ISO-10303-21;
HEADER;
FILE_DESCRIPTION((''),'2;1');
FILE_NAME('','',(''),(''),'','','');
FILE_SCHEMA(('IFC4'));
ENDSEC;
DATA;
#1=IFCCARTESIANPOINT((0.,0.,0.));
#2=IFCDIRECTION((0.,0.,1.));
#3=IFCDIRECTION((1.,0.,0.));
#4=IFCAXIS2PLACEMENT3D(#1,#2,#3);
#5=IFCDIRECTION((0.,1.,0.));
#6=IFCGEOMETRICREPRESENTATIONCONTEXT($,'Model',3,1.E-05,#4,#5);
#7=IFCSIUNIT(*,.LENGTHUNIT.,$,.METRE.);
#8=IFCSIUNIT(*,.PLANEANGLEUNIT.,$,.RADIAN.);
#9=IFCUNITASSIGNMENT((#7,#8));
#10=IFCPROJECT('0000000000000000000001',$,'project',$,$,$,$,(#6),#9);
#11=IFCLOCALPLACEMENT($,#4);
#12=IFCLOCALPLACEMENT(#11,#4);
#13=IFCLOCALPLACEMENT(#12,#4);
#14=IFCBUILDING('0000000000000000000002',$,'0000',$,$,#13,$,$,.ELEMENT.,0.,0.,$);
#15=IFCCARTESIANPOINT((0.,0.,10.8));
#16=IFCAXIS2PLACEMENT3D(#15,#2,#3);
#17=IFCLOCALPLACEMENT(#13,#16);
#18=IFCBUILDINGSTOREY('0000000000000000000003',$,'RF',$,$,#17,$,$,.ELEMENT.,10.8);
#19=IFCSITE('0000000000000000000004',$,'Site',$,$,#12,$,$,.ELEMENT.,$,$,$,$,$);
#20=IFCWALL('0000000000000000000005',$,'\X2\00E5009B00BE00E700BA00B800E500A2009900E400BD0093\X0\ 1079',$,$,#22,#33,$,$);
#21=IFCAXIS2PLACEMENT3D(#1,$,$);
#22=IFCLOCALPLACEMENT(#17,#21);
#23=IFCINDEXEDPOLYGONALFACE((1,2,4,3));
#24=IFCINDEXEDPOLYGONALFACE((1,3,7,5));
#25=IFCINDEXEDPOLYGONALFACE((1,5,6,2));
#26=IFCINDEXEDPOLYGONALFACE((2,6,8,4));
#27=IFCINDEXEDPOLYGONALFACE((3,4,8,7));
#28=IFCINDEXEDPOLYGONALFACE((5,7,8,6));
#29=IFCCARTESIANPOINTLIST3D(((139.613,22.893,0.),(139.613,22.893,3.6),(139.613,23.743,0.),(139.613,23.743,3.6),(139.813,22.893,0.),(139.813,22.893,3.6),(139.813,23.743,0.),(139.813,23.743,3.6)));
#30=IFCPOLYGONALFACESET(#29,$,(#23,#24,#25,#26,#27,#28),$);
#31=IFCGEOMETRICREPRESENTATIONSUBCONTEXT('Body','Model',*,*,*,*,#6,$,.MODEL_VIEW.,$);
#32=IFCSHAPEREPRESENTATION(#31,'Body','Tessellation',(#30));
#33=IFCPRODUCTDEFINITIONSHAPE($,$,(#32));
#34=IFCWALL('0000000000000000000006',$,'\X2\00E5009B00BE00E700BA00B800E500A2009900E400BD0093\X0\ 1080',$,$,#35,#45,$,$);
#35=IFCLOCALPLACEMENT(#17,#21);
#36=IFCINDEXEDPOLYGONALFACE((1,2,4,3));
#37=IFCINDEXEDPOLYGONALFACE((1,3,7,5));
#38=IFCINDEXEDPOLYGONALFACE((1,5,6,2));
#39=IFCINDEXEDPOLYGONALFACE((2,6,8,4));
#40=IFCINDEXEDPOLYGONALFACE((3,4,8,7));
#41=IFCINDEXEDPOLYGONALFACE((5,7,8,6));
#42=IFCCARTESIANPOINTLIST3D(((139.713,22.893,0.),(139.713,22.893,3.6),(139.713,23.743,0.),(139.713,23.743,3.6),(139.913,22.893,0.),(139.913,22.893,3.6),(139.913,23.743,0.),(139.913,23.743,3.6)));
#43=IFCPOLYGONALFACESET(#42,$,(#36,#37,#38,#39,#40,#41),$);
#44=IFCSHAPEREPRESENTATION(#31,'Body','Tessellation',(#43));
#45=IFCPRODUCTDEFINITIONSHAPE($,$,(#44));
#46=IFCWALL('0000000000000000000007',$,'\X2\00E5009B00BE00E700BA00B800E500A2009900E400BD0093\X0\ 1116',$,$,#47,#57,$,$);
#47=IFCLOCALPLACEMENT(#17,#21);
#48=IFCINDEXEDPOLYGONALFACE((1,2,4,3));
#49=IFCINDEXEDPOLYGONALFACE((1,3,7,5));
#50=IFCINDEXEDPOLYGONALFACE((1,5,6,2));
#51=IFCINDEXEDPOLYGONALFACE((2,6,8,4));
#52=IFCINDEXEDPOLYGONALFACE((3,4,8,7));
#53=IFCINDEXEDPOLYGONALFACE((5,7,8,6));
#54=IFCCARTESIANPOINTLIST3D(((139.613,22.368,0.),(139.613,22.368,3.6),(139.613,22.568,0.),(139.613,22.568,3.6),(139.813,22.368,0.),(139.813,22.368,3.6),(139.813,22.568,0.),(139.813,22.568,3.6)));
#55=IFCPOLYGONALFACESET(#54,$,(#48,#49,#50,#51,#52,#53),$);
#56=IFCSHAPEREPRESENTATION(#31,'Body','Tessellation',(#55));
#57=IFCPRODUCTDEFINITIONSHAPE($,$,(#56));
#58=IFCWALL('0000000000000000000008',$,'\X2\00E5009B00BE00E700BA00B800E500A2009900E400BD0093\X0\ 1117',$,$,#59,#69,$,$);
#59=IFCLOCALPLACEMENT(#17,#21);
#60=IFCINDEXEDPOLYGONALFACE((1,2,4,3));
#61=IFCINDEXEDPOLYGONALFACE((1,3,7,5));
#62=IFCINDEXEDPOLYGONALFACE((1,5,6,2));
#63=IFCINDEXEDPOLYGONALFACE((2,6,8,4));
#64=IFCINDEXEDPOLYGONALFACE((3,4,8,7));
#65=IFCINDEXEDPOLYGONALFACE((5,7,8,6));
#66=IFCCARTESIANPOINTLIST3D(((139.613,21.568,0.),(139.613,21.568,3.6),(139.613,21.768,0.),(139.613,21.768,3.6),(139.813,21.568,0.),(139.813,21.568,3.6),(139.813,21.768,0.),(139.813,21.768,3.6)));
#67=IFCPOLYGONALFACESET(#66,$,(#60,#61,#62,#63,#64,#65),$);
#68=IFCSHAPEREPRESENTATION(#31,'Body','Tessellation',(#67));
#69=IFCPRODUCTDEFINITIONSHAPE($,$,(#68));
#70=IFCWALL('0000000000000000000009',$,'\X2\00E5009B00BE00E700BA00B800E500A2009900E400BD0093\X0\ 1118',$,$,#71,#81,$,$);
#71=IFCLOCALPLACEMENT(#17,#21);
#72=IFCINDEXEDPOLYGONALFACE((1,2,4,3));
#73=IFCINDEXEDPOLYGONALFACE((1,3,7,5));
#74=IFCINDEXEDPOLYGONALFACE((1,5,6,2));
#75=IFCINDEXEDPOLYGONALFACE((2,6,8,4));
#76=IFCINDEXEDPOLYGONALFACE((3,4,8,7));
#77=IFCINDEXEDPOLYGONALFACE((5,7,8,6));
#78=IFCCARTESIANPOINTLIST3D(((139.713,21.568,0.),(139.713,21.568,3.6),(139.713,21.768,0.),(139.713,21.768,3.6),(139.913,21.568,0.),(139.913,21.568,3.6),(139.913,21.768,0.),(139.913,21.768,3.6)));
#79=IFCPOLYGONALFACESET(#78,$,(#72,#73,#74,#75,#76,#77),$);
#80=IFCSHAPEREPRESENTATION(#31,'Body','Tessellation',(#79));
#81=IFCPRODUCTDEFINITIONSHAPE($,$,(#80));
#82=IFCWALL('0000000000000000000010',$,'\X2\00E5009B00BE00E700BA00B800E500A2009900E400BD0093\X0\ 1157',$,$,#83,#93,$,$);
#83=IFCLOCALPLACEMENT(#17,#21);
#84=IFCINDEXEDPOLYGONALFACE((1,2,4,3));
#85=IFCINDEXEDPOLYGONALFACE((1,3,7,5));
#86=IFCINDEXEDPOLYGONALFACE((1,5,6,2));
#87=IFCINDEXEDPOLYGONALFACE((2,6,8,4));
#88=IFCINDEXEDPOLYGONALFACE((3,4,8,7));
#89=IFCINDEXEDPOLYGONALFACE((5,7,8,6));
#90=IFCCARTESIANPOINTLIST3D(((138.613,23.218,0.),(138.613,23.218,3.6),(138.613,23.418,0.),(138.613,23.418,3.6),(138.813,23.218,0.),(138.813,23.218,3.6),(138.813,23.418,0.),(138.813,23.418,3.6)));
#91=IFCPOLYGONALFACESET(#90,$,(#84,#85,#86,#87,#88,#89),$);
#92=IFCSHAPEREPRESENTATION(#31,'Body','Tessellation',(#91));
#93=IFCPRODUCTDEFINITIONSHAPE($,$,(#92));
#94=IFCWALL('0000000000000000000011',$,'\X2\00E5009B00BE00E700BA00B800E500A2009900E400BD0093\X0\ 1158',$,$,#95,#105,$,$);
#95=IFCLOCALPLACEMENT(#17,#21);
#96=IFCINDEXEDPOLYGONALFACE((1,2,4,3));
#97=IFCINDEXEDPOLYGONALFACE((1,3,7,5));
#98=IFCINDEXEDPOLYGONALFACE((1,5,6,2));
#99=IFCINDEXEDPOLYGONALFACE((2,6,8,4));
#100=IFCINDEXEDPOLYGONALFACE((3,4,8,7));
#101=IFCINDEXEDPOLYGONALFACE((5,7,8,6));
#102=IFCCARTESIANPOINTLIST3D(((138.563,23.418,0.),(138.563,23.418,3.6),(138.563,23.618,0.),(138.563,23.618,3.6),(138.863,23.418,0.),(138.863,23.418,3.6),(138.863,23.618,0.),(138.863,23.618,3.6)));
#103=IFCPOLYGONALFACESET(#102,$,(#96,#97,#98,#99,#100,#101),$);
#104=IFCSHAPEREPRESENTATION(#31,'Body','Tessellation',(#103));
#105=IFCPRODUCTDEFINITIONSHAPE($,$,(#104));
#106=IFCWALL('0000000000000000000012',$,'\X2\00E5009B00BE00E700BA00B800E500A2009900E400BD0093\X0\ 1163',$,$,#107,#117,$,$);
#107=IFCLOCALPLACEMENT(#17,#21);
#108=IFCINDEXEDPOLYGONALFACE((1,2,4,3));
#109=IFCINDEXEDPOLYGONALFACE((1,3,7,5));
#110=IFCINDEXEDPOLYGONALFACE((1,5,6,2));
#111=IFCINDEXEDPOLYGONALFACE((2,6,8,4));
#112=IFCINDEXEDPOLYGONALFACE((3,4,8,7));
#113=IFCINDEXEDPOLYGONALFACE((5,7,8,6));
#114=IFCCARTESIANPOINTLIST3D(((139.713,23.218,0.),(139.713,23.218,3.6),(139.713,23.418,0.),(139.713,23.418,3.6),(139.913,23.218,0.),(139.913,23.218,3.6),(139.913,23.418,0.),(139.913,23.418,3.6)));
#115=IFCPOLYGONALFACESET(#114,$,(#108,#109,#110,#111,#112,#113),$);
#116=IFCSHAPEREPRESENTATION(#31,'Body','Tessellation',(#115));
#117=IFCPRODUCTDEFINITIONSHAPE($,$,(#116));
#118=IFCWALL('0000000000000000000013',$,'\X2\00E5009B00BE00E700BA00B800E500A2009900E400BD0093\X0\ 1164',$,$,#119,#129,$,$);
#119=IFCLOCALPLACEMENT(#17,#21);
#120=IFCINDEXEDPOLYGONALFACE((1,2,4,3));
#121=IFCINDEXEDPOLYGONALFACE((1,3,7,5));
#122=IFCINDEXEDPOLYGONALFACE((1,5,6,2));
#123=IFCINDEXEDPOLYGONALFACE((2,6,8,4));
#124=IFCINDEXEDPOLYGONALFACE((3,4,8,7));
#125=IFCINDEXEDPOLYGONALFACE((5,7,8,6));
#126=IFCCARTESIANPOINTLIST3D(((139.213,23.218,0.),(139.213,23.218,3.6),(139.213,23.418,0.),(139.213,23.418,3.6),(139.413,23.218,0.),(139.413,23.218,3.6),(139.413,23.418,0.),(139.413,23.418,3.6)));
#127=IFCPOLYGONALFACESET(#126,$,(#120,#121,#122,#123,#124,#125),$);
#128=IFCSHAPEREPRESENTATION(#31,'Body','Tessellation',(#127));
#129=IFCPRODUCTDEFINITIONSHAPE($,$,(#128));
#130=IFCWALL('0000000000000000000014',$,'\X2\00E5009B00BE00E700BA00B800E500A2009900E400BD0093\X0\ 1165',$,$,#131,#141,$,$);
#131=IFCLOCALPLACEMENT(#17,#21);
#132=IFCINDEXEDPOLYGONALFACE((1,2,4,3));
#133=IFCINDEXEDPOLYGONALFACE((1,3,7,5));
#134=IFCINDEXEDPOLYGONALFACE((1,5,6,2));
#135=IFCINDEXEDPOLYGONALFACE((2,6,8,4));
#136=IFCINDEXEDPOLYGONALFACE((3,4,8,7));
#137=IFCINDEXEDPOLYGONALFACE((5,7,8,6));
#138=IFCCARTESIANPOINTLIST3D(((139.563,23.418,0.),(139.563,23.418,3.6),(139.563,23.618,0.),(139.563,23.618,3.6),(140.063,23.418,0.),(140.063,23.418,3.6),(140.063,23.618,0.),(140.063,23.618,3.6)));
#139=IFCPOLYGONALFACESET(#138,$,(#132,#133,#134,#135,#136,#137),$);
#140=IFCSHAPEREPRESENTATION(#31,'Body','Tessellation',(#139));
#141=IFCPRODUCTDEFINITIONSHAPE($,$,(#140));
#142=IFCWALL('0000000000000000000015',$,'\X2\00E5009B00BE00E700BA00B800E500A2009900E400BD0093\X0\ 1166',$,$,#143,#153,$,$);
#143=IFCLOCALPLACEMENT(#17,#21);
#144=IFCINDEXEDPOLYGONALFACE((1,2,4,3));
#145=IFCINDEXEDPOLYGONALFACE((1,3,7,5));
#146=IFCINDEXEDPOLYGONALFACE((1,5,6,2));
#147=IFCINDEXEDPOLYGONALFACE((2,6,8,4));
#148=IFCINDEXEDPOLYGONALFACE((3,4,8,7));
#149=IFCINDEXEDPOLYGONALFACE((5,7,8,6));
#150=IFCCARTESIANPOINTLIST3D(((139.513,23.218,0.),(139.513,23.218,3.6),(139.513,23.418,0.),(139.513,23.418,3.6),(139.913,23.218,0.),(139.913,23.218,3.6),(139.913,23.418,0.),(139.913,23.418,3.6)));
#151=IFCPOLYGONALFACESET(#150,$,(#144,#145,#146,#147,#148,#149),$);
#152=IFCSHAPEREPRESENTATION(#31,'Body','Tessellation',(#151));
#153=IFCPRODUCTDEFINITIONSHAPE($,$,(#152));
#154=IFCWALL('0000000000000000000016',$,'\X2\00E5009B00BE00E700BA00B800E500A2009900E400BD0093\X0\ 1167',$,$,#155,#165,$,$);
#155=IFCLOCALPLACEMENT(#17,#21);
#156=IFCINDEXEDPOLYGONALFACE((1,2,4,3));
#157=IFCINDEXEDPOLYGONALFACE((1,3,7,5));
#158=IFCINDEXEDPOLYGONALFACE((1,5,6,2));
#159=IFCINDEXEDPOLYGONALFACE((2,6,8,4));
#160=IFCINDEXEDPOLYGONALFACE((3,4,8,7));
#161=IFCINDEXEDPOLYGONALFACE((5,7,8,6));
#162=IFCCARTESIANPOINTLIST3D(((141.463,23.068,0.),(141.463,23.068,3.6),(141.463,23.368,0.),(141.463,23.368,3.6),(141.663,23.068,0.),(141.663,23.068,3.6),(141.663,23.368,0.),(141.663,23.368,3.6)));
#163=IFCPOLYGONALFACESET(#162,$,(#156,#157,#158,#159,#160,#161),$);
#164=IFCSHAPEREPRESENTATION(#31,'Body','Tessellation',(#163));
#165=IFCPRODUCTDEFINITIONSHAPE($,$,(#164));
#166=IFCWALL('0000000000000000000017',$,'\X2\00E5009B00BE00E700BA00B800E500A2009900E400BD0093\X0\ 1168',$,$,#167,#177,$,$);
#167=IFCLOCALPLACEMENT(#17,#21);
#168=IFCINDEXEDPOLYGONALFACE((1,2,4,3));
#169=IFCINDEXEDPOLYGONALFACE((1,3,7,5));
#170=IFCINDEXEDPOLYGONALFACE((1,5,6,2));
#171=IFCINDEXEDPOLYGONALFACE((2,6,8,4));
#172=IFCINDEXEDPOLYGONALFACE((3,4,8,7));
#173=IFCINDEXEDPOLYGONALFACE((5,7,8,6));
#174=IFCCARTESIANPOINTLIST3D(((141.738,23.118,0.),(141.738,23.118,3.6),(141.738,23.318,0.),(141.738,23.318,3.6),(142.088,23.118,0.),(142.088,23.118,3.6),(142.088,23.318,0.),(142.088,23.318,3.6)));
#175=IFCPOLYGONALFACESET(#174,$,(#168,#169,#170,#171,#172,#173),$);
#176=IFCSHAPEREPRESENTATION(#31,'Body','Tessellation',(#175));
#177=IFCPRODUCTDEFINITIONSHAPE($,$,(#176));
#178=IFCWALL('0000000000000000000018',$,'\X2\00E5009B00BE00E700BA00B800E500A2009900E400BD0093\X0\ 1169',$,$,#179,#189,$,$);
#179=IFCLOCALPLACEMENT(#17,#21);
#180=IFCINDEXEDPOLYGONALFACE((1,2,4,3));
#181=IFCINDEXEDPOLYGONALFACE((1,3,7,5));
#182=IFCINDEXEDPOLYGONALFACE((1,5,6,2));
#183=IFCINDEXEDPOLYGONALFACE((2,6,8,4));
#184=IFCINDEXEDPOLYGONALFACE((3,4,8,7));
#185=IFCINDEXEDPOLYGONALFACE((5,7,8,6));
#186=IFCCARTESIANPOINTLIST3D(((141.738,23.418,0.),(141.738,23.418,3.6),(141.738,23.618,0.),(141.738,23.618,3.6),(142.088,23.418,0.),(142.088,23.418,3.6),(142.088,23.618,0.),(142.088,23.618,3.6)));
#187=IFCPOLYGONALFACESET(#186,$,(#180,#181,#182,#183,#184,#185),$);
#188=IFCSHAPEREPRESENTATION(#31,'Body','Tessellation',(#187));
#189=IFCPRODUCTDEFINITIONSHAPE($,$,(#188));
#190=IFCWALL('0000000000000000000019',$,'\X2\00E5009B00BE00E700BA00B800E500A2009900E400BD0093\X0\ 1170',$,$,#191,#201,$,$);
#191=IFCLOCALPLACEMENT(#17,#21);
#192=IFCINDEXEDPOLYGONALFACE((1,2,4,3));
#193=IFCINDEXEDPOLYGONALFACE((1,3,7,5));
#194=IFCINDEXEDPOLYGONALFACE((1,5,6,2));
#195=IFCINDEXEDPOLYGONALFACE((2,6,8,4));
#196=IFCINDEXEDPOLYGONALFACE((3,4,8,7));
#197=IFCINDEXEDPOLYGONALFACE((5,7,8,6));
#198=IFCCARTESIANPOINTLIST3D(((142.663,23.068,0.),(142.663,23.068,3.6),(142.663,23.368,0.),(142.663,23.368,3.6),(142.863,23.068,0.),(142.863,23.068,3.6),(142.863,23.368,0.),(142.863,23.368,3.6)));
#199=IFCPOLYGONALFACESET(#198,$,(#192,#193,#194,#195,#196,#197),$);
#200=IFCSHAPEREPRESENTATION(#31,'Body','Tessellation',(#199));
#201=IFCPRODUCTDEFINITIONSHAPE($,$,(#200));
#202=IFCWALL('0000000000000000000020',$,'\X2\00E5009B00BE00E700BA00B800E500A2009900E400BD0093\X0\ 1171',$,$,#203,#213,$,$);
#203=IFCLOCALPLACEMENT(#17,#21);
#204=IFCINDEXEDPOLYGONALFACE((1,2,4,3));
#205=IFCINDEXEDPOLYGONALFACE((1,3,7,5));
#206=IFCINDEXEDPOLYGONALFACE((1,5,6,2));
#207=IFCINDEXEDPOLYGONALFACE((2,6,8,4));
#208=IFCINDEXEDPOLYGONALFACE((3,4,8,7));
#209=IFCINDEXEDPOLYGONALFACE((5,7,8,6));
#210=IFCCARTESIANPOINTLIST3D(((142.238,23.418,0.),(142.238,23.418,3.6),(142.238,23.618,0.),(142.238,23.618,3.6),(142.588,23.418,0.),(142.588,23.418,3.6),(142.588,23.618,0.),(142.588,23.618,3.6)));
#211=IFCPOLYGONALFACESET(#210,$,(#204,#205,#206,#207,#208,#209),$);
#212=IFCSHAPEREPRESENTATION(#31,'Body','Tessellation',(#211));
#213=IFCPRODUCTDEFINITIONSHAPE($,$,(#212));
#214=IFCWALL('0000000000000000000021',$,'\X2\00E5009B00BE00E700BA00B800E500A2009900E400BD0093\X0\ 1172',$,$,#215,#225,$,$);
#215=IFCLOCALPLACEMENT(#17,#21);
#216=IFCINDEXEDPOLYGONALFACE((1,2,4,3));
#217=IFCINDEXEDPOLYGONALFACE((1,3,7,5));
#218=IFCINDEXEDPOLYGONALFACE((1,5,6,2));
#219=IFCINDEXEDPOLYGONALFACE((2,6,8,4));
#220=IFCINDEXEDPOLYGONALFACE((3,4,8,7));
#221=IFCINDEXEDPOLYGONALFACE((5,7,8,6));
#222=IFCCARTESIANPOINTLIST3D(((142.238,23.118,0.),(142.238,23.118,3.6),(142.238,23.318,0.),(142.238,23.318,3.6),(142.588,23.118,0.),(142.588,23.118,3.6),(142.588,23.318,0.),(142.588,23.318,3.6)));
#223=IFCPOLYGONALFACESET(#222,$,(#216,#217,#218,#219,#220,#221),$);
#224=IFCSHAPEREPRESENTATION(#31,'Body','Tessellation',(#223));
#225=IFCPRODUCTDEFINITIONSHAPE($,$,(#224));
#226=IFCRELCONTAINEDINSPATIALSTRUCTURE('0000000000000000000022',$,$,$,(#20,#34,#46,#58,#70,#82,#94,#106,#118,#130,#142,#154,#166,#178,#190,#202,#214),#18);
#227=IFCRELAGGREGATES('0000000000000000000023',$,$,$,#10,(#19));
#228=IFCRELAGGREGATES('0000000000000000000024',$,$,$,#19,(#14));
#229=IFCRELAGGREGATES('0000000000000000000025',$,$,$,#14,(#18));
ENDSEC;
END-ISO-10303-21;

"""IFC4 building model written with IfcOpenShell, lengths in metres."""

from ifc_helpers import new_model, si_unit, direction, frame, frame_2d, origin_with_axes, place, context, subcontext, project, spatial, rectangle, extrude, element, save


model = new_model("IFC4")

# Units and contexts
model_context = context("Model", 3, precision=1e-05, world=origin_with_axes(), true_north=direction((0.0, 1.0, 0.0)))
body_context = subcontext(model_context, "Body", "Model", "MODEL_VIEW")
ifc_project = project(units=[si_unit("LENGTHUNIT", "METRE"), si_unit("PLANEANGLEUNIT", "RADIAN")], contexts=[model_context])

# Site, building, storey
placement = place(None, origin_with_axes())
site_placement = place(placement, origin_with_axes())
site = spatial("IfcSite", under=ifc_project, at=site_placement, Name="Site", CompositionType="ELEMENT")
building_placement = place(site_placement, origin_with_axes())
building = spatial("IfcBuilding", under=site, at=building_placement, Name="0000", CompositionType="ELEMENT", ElevationOfRefHeight=0.0, ElevationOfTerrain=0.0)
storey_placement = place(building_placement, frame((0.0, 0.0, 10.8), z_axis=(0.0, 0.0, 1.0), x_axis=(1.0, 0.0, 0.0)))
storey = spatial("IfcBuildingStorey", under=building, at=storey_placement, Name="RF", CompositionType="ELEMENT", Elevation=10.8)

# Walls
for number, where, z_axis, x_axis, name in (
    (1, (139.713, 23.318, 0.0), (0.0, 0.0, 1.0), (0.0, -1.0, 0.0), "å\u009b¾çº¸å¢\u0099ä½\u0093 1079"),
    (2, (139.813, 23.318, 0.0), (0.0, 0.0, 1.0), (0.0, -1.0, 0.0), "å\u009b¾çº¸å¢\u0099ä½\u0093 1080"),
):
    element("IfcWall", number, at=place(storey_placement, frame(where, z_axis=z_axis, x_axis=x_axis)), inside=storey, Name=name, context=body_context, shape_type="SweptSolid", body=[
        extrude(rectangle(XDim=0.85, YDim=0.2, at=frame_2d((0.0, 0.0), x_axis=(1.0, 0.0, 0.0))), frame((0.0, 0.0, 0.0), z_axis=(0.0, 0.0, 1.0)), (0.0, 0.0, 1.0), 3.6),
    ])
for number, where, z_axis, x_axis, name in (
    (3, (139.713, 22.468, 0.0), (0.0, 0.0, 1.0), (1.0, 0.0, 0.0), "å\u009b¾çº¸å¢\u0099ä½\u0093 1116"),
    (4, (139.713, 21.668, 0.0), (0.0, 0.0, 1.0), (1.0, 0.0, 0.0), "å\u009b¾çº¸å¢\u0099ä½\u0093 1117"),
    (5, (139.813, 21.668, 0.0), (0.0, 0.0, 1.0), (0.0, -1.0, 0.0), "å\u009b¾çº¸å¢\u0099ä½\u0093 1118"),
    (6, (138.713, 23.318, 0.0), (0.0, 0.0, 1.0), (-1.0, 0.0, 0.0), "å\u009b¾çº¸å¢\u0099ä½\u0093 1157"),
):
    element("IfcWall", number, at=place(storey_placement, frame(where, z_axis=z_axis, x_axis=x_axis)), inside=storey, Name=name, context=body_context, shape_type="SweptSolid", body=[
        extrude(rectangle(XDim=0.2, YDim=0.2, at=frame_2d((0.0, 0.0), x_axis=(1.0, 0.0, 0.0))), frame((0.0, 0.0, 0.0), z_axis=(0.0, 0.0, 1.0)), (0.0, 0.0, 1.0), 3.6),
    ])
wall_1_placement = place(storey_placement, frame((138.713, 23.518, 0.0), z_axis=(0.0, 0.0, 1.0), x_axis=(-1.0, 0.0, 0.0)))
element("IfcWall", 7, at=wall_1_placement, inside=storey, Name="å\u009b¾çº¸å¢\u0099ä½\u0093 1158", context=body_context, shape_type="SweptSolid", body=[
    extrude(rectangle(XDim=0.3, YDim=0.2, at=frame_2d((0.0, 0.0), x_axis=(1.0, 0.0, 0.0))), frame((0.0, 0.0, 0.0), z_axis=(0.0, 0.0, 1.0)), (0.0, 0.0, 1.0), 3.6),
])
for number, where, z_axis, x_axis, name in (
    (8, (139.813, 23.318, 0.0), (0.0, 0.0, 1.0), (0.0, 1.0, 0.0), "å\u009b¾çº¸å¢\u0099ä½\u0093 1163"),
    (9, (139.313, 23.318, 0.0), (0.0, 0.0, 1.0), (0.0, 1.0, 0.0), "å\u009b¾çº¸å¢\u0099ä½\u0093 1164"),
):
    element("IfcWall", number, at=place(storey_placement, frame(where, z_axis=z_axis, x_axis=x_axis)), inside=storey, Name=name, context=body_context, shape_type="SweptSolid", body=[
        extrude(rectangle(XDim=0.2, YDim=0.2, at=frame_2d((0.0, 0.0), x_axis=(1.0, 0.0, 0.0))), frame((0.0, 0.0, 0.0), z_axis=(0.0, 0.0, 1.0)), (0.0, 0.0, 1.0), 3.6),
    ])
wall_2_placement = place(storey_placement, frame((139.813, 23.518, 0.0), z_axis=(0.0, 0.0, 1.0), x_axis=(-1.0, 0.0, 0.0)))
element("IfcWall", 10, at=wall_2_placement, inside=storey, Name="å\u009b¾çº¸å¢\u0099ä½\u0093 1165", context=body_context, shape_type="SweptSolid", body=[
    extrude(rectangle(XDim=0.5, YDim=0.2, at=frame_2d((0.0, 0.0), x_axis=(1.0, 0.0, 0.0))), frame((0.0, 0.0, 0.0), z_axis=(0.0, 0.0, 1.0)), (0.0, 0.0, 1.0), 3.6),
])
wall_3_placement = place(storey_placement, frame((139.713, 23.318, 0.0), z_axis=(0.0, 0.0, 1.0), x_axis=(-1.0, 0.0, 0.0)))
element("IfcWall", 11, at=wall_3_placement, inside=storey, Name="å\u009b¾çº¸å¢\u0099ä½\u0093 1166", context=body_context, shape_type="SweptSolid", body=[
    extrude(rectangle(XDim=0.4, YDim=0.2, at=frame_2d((0.0, 0.0), x_axis=(1.0, 0.0, 0.0))), frame((0.0, 0.0, 0.0), z_axis=(0.0, 0.0, 1.0)), (0.0, 0.0, 1.0), 3.6),
])
wall_4_placement = place(storey_placement, frame((141.563, 23.218, 0.0), z_axis=(0.0, 0.0, 1.0), x_axis=(0.0, 1.0, 0.0)))
element("IfcWall", 12, at=wall_4_placement, inside=storey, Name="å\u009b¾çº¸å¢\u0099ä½\u0093 1167", context=body_context, shape_type="SweptSolid", body=[
    extrude(rectangle(XDim=0.3, YDim=0.2, at=frame_2d((0.0, 0.0), x_axis=(1.0, 0.0, 0.0))), frame((0.0, 0.0, 0.0), z_axis=(0.0, 0.0, 1.0)), (0.0, 0.0, 1.0), 3.6),
])
for number, where, z_axis, x_axis, name in (
    (13, (141.913, 23.218, 0.0), (0.0, 0.0, 1.0), (-1.0, 0.0, 0.0), "å\u009b¾çº¸å¢\u0099ä½\u0093 1168"),
    (14, (141.913, 23.518, 0.0), (0.0, 0.0, 1.0), (-1.0, 0.0, 0.0), "å\u009b¾çº¸å¢\u0099ä½\u0093 1169"),
):
    element("IfcWall", number, at=place(storey_placement, frame(where, z_axis=z_axis, x_axis=x_axis)), inside=storey, Name=name, context=body_context, shape_type="SweptSolid", body=[
        extrude(rectangle(XDim=0.35, YDim=0.2, at=frame_2d((0.0, 0.0), x_axis=(1.0, 0.0, 0.0))), frame((0.0, 0.0, 0.0), z_axis=(0.0, 0.0, 1.0)), (0.0, 0.0, 1.0), 3.6),
    ])
wall_5_placement = place(storey_placement, frame((142.763, 23.218, 0.0), z_axis=(0.0, 0.0, 1.0), x_axis=(0.0, 1.0, 0.0)))
element("IfcWall", 15, at=wall_5_placement, inside=storey, Name="å\u009b¾çº¸å¢\u0099ä½\u0093 1170", context=body_context, shape_type="SweptSolid", body=[
    extrude(rectangle(XDim=0.3, YDim=0.2, at=frame_2d((0.0, 0.0), x_axis=(1.0, 0.0, 0.0))), frame((0.0, 0.0, 0.0), z_axis=(0.0, 0.0, 1.0)), (0.0, 0.0, 1.0), 3.6),
])
for number, where, z_axis, x_axis, name in (
    (16, (142.413, 23.518, 0.0), (0.0, 0.0, 1.0), (1.0, 0.0, 0.0), "å\u009b¾çº¸å¢\u0099ä½\u0093 1171"),
    (17, (142.413, 23.218, 0.0), (0.0, 0.0, 1.0), (1.0, 0.0, 0.0), "å\u009b¾çº¸å¢\u0099ä½\u0093 1172"),
):
    element("IfcWall", number, at=place(storey_placement, frame(where, z_axis=z_axis, x_axis=x_axis)), inside=storey, Name=name, context=body_context, shape_type="SweptSolid", body=[
        extrude(rectangle(XDim=0.35, YDim=0.2, at=frame_2d((0.0, 0.0), x_axis=(1.0, 0.0, 0.0))), frame((0.0, 0.0, 0.0), z_axis=(0.0, 0.0, 1.0)), (0.0, 0.0, 1.0), 3.6),
    ])

save(model, "model.ifc")
